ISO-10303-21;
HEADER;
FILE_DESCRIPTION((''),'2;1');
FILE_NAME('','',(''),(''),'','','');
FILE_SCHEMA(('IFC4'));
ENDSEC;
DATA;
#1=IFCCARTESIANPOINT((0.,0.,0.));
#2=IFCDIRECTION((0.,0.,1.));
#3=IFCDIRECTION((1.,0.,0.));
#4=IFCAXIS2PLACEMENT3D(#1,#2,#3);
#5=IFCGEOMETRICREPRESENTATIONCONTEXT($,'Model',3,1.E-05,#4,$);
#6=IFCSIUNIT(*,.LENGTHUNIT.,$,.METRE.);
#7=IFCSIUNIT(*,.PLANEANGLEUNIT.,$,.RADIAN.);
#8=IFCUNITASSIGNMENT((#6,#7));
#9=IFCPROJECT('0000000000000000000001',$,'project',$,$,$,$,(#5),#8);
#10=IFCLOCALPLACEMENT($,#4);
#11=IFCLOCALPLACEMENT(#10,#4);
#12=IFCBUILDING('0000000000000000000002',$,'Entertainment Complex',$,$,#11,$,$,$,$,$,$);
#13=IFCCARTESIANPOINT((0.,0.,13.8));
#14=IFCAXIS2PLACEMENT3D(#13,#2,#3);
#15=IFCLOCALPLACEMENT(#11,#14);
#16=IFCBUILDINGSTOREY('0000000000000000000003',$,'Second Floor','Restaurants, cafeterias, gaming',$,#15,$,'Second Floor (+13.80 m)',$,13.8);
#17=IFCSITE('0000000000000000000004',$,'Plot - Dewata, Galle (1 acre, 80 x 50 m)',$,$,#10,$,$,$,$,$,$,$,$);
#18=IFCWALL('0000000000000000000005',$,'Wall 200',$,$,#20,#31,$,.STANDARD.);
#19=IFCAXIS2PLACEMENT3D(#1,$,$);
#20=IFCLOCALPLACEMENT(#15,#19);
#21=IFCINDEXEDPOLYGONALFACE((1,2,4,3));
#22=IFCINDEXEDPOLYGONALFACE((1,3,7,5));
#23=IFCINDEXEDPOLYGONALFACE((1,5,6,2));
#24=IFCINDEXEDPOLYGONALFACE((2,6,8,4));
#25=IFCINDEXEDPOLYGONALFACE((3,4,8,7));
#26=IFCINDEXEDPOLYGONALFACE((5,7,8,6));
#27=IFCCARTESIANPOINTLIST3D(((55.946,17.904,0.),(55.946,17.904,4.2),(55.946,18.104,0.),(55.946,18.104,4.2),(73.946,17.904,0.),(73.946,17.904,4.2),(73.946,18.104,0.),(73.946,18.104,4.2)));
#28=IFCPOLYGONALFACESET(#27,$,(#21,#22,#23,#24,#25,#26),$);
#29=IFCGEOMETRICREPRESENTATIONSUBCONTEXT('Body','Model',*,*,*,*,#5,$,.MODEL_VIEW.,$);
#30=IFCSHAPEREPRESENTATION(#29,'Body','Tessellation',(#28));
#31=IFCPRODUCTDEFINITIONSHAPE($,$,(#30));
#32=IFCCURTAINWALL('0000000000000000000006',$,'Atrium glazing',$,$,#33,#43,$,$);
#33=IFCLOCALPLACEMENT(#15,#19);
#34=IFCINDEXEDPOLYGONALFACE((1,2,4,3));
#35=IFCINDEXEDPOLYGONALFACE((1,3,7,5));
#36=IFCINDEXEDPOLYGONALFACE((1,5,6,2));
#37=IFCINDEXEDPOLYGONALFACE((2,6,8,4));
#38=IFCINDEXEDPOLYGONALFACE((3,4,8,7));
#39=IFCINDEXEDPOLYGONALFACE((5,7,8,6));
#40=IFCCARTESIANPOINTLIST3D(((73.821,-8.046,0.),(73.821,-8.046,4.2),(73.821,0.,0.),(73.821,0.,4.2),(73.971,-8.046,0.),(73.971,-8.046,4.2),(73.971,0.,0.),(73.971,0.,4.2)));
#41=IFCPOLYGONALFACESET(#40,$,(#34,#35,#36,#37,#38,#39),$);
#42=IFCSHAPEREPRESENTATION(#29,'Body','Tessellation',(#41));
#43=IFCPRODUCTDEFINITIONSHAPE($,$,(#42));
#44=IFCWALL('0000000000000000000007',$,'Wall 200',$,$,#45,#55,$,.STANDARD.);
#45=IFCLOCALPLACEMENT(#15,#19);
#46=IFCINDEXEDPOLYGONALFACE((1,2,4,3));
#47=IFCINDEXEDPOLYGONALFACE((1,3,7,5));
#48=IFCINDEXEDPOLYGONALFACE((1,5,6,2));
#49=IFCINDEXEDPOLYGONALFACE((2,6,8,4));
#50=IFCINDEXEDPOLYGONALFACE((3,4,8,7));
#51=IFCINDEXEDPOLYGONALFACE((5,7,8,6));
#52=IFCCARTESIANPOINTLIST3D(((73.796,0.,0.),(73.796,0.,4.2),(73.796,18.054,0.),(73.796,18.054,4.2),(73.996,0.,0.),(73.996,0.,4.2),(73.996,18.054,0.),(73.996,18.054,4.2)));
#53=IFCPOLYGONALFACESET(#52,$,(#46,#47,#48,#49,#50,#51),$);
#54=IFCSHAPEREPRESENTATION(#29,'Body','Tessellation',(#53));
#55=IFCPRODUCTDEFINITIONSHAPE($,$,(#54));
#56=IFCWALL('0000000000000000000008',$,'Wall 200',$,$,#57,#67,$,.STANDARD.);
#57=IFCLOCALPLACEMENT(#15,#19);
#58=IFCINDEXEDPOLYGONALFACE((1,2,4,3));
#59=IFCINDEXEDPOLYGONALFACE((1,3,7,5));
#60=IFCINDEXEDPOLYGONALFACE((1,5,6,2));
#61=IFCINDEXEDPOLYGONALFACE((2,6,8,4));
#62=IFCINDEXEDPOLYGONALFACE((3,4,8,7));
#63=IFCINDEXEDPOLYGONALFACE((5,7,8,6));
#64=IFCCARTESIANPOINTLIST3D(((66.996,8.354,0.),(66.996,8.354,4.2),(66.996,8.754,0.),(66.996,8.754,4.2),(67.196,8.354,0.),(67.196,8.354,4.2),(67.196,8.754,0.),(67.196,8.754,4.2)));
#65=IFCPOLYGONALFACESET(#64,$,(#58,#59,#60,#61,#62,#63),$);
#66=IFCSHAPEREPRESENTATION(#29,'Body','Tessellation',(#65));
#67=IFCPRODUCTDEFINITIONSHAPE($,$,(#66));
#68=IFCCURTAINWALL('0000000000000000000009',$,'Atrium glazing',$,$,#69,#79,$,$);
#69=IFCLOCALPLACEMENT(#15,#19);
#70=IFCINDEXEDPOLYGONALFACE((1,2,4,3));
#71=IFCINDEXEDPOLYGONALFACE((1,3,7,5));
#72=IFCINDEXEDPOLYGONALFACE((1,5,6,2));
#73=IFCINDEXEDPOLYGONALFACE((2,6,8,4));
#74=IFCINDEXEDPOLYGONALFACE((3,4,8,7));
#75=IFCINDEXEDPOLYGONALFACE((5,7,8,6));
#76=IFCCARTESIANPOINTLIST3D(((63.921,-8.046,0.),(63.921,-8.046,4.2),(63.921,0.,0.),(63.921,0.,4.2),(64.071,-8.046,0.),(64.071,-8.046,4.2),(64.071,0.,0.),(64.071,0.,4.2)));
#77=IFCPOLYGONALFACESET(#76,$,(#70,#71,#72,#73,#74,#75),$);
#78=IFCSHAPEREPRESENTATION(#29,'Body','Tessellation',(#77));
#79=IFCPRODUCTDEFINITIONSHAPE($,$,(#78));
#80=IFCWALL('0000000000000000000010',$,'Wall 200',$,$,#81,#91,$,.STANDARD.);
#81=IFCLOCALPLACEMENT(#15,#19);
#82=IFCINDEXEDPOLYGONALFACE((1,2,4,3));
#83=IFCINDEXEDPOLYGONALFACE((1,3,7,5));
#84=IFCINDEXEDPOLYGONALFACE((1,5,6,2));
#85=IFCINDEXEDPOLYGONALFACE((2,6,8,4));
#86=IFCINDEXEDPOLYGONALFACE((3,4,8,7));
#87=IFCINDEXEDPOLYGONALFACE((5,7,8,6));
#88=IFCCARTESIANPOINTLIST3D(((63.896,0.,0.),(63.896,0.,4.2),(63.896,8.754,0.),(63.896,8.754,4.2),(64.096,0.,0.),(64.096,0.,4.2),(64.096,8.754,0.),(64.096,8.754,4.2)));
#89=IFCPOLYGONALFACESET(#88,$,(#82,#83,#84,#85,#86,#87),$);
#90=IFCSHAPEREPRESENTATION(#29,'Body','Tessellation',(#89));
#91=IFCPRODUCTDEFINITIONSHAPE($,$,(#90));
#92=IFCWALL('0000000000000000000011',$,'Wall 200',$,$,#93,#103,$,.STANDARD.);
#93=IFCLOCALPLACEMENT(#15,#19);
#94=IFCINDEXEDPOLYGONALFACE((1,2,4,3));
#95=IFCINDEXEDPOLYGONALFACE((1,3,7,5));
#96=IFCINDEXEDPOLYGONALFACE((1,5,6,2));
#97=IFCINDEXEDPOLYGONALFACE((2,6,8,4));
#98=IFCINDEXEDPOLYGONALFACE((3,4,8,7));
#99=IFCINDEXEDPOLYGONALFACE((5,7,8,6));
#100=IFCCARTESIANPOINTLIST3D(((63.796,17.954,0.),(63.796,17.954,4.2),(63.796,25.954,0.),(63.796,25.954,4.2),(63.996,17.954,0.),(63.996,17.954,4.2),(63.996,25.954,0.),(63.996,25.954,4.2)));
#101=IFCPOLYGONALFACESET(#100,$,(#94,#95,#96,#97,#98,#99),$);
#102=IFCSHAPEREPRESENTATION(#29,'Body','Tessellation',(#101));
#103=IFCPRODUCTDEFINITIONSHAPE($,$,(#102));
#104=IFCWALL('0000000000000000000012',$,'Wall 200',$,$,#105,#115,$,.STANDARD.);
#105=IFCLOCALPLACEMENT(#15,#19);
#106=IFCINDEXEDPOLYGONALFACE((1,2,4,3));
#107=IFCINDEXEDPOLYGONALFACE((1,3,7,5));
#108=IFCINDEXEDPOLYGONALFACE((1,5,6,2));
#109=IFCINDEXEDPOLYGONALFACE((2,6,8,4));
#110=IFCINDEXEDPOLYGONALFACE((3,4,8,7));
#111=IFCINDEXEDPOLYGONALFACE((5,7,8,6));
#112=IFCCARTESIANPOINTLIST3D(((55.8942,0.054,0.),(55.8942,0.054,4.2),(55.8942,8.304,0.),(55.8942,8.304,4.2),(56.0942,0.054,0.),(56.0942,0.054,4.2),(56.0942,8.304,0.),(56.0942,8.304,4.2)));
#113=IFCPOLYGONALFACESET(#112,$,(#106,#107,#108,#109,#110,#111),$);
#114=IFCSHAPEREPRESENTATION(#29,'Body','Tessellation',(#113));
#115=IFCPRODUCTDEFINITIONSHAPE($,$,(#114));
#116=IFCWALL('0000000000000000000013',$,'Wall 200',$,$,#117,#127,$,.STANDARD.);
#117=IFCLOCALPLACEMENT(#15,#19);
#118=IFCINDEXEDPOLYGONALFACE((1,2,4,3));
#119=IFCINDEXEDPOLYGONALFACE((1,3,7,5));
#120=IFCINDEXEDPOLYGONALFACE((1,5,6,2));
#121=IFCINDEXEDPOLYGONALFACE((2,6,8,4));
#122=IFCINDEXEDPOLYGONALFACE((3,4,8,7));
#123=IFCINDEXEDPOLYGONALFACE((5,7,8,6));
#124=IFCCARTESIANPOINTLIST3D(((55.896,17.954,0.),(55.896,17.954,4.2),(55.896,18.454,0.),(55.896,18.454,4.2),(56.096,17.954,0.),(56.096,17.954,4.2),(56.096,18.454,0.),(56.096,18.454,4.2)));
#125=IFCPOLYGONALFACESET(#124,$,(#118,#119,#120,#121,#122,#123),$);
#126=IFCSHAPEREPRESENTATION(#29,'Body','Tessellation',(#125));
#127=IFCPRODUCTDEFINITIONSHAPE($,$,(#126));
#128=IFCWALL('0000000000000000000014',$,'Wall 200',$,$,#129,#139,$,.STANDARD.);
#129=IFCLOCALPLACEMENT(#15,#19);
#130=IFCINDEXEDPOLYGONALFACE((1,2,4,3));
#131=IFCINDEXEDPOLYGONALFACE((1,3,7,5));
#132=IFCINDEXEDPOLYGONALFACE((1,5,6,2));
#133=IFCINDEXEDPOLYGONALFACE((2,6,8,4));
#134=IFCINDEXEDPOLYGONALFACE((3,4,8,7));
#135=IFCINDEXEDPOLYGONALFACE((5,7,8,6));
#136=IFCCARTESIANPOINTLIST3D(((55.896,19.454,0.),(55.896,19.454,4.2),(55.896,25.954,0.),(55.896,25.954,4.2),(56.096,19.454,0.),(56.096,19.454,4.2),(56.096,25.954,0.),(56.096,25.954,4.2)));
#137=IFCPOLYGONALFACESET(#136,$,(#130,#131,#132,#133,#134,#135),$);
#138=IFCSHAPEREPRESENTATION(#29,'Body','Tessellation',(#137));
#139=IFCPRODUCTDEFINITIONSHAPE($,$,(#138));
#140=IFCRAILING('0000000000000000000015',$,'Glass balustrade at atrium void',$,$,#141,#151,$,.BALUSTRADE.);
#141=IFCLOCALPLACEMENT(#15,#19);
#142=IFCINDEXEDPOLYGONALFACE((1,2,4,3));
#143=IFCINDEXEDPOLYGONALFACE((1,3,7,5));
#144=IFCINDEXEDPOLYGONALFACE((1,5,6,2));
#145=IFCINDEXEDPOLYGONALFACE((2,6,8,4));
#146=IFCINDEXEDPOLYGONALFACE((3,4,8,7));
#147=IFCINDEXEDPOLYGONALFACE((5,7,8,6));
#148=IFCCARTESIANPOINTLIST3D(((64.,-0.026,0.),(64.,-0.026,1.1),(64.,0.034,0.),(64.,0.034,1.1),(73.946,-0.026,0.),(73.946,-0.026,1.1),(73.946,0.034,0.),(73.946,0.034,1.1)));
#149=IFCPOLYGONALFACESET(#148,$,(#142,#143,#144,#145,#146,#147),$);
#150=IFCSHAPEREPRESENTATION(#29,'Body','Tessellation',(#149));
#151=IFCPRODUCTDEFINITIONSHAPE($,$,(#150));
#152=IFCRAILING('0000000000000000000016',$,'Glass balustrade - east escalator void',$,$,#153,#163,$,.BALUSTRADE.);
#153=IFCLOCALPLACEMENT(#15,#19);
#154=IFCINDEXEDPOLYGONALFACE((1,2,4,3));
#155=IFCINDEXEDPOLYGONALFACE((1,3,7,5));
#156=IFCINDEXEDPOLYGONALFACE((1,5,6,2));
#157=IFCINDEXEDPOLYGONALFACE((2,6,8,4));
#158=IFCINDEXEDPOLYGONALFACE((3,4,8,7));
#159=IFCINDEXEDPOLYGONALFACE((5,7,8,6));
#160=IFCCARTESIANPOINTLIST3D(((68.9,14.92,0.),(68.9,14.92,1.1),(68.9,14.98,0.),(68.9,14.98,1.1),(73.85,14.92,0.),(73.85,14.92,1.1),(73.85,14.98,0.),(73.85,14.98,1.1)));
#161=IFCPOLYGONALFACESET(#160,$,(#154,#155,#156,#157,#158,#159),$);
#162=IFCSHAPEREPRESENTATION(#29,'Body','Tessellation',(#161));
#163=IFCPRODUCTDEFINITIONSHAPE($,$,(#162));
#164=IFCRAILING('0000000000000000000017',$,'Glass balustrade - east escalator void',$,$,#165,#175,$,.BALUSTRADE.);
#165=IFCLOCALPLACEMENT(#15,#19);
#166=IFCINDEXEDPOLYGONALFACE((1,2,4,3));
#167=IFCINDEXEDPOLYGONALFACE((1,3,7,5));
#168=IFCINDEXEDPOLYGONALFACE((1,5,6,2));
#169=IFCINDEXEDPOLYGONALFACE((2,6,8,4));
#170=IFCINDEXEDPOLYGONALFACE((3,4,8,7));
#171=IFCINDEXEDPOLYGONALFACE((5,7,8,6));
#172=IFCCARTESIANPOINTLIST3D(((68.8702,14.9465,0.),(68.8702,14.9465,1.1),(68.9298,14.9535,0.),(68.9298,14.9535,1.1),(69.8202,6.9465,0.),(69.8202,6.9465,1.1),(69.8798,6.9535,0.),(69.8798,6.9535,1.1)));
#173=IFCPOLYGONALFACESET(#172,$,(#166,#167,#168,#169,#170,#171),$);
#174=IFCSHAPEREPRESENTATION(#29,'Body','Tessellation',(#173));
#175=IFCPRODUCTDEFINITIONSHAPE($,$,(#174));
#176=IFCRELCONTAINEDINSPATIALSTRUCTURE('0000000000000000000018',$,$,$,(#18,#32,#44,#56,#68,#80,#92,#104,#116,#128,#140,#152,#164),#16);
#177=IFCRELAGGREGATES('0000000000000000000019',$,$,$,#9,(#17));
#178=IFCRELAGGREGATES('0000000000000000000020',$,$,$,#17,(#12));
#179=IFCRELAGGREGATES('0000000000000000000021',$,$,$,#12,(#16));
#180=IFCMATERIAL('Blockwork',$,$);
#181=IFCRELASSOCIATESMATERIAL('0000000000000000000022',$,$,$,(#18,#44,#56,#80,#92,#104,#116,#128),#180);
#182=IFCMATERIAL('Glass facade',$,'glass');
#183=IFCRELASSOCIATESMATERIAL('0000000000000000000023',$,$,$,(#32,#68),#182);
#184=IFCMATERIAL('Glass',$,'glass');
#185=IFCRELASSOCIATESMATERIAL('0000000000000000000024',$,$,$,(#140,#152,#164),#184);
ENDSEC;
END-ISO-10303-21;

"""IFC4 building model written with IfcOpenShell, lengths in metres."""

from ifc_helpers import new_model, si_unit, frame, origin_with_axes, place, context, subcontext, project, spatial, polyline, outline, extrude, material, element, save


model = new_model("IFC4")

# Units and contexts
model_context = context("Model", 3, precision=1e-05, world=origin_with_axes())
body_context = subcontext(model_context, "Body", "Model", "MODEL_VIEW")
ifc_project = project(units=[si_unit("LENGTHUNIT", "METRE"), si_unit("PLANEANGLEUNIT", "RADIAN")], contexts=[model_context])

# Site, building, storey
site_placement = place(None, origin_with_axes())
site = spatial("IfcSite", under=ifc_project, at=site_placement, Name="Plot - Dewata, Galle (1 acre, 80 x 50 m)")
building_placement = place(site_placement, origin_with_axes())
building = spatial("IfcBuilding", under=site, at=building_placement, Name="Entertainment Complex")
storey_placement = place(building_placement, frame((0.0, 0.0, 13.8), z_axis=(0.0, 0.0, 1.0), x_axis=(1.0, 0.0, 0.0)))
storey = spatial("IfcBuildingStorey", under=building, at=storey_placement, Name="Second Floor", Description="Restaurants, cafeterias, gaming", LongName="Second Floor (+13.80 m)", Elevation=13.8)

# Shared definitions
ifc_material_1 = material(Name="Glass facade", Category="glass")

# Wall
ifc_material_2 = material(Name="Blockwork")
wall_1_placement = place(storey_placement, frame((55.946, 18.004, 0.0), z_axis=(0.0, 0.0, 1.0), x_axis=(1.0, 0.0, 0.0)))
element("IfcWall", 1, at=wall_1_placement, inside=storey, material=ifc_material_2, Name="Wall 200", PredefinedType="STANDARD", context=body_context, shape_type="SweptSolid", body=[
    extrude(outline(polyline([(0.0, -0.1), (18.0, -0.1), (18.0, 0.1), (0.0, 0.1), (0.0, -0.1)])), origin_with_axes(), (0.0, 0.0, 1.0), 4.2),
])

# Curtain wall
curtain_wall_1_placement = place(storey_placement, frame((73.896, -8.046, 0.0), z_axis=(0.0, 0.0, 1.0), x_axis=(0.0, 1.0, 0.0)))
element("IfcCurtainWall", 2, at=curtain_wall_1_placement, inside=storey, material=ifc_material_1, Name="Atrium glazing", context=body_context, shape_type="SweptSolid", body=[
    extrude(outline(polyline([(0.0, -0.075), (8.046, -0.075), (8.046, 0.075), (0.0, 0.075), (0.0, -0.075)])), origin_with_axes(), (0.0, 0.0, 1.0), 4.2),
])

# Walls
wall_2_placement = place(storey_placement, frame((73.896, 0.0, 0.0), z_axis=(0.0, 0.0, 1.0), x_axis=(0.0, 1.0, 0.0)))
element("IfcWall", 3, at=wall_2_placement, inside=storey, material=ifc_material_2, Name="Wall 200", PredefinedType="STANDARD", context=body_context, shape_type="SweptSolid", body=[
    extrude(outline(polyline([(0.0, -0.1), (18.054, -0.1), (18.054, 0.1), (0.0, 0.1), (0.0, -0.1)])), origin_with_axes(), (0.0, 0.0, 1.0), 4.2),
])
wall_3_placement = place(storey_placement, frame((67.096, 8.354, 0.0), z_axis=(0.0, 0.0, 1.0), x_axis=(0.0, 1.0, 0.0)))
element("IfcWall", 4, at=wall_3_placement, inside=storey, material=ifc_material_2, Name="Wall 200", PredefinedType="STANDARD", context=body_context, shape_type="SweptSolid", body=[
    extrude(outline(polyline([(0.0, -0.1), (0.4, -0.1), (0.4, 0.1), (0.0, 0.1), (0.0, -0.1)])), origin_with_axes(), (0.0, 0.0, 1.0), 4.2),
])

# Curtain wall
curtain_wall_2_placement = place(storey_placement, frame((63.996, -8.046, 0.0), z_axis=(0.0, 0.0, 1.0), x_axis=(0.0, 1.0, 0.0)))
element("IfcCurtainWall", 5, at=curtain_wall_2_placement, inside=storey, material=ifc_material_1, Name="Atrium glazing", context=body_context, shape_type="SweptSolid", body=[
    extrude(outline(polyline([(0.0, -0.075), (8.046, -0.075), (8.046, 0.075), (0.0, 0.075), (0.0, -0.075)])), origin_with_axes(), (0.0, 0.0, 1.0), 4.2),
])

# Walls
wall_4_placement = place(storey_placement, frame((63.996, 0.0, 0.0), z_axis=(0.0, 0.0, 1.0), x_axis=(0.0, 1.0, 0.0)))
element("IfcWall", 6, at=wall_4_placement, inside=storey, material=ifc_material_2, Name="Wall 200", PredefinedType="STANDARD", context=body_context, shape_type="SweptSolid", body=[
    extrude(outline(polyline([(0.0, -0.1), (8.754, -0.1), (8.754, 0.1), (0.0, 0.1), (0.0, -0.1)])), origin_with_axes(), (0.0, 0.0, 1.0), 4.2),
])
wall_5_placement = place(storey_placement, frame((63.896, 17.954, 0.0), z_axis=(0.0, 0.0, 1.0), x_axis=(0.0, 1.0, 0.0)))
element("IfcWall", 7, at=wall_5_placement, inside=storey, material=ifc_material_2, Name="Wall 200", PredefinedType="STANDARD", context=body_context, shape_type="SweptSolid", body=[
    extrude(outline(polyline([(0.0, -0.1), (8.0, -0.1), (8.0, 0.1), (0.0, 0.1), (0.0, -0.1)])), origin_with_axes(), (0.0, 0.0, 1.0), 4.2),
])
wall_6_placement = place(storey_placement, frame((55.9942, 0.054, 0.0), z_axis=(0.0, 0.0, 1.0), x_axis=(0.0, 1.0, 0.0)))
element("IfcWall", 8, at=wall_6_placement, inside=storey, material=ifc_material_2, Name="Wall 200", PredefinedType="STANDARD", context=body_context, shape_type="SweptSolid", body=[
    extrude(outline(polyline([(0.0, -0.1), (8.25, -0.1), (8.25, 0.1), (0.0, 0.1), (0.0, -0.1)])), origin_with_axes(), (0.0, 0.0, 1.0), 4.2),
])
wall_7_placement = place(storey_placement, frame((55.996, 17.954, 0.0), z_axis=(0.0, 0.0, 1.0), x_axis=(0.0, 1.0, 0.0)))
element("IfcWall", 9, at=wall_7_placement, inside=storey, material=ifc_material_2, Name="Wall 200", PredefinedType="STANDARD", context=body_context, shape_type="SweptSolid", body=[
    extrude(outline(polyline([(0.0, -0.1), (0.5, -0.1), (0.5, 0.1), (0.0, 0.1), (0.0, -0.1)])), origin_with_axes(), (0.0, 0.0, 1.0), 4.2),
])
wall_8_placement = place(storey_placement, frame((55.996, 19.454, 0.0), z_axis=(0.0, 0.0, 1.0), x_axis=(0.0, 1.0, 0.0)))
element("IfcWall", 10, at=wall_8_placement, inside=storey, material=ifc_material_2, Name="Wall 200", PredefinedType="STANDARD", context=body_context, shape_type="SweptSolid", body=[
    extrude(outline(polyline([(0.0, -0.1), (6.5, -0.1), (6.5, 0.1), (0.0, 0.1), (0.0, -0.1)])), origin_with_axes(), (0.0, 0.0, 1.0), 4.2),
])

# Railings
ifc_material_3 = material(Name="Glass", Category="glass")
railing_1_placement = place(storey_placement, frame((64.0, 0.004, 0.0), z_axis=(0.0, 0.0, 1.0), x_axis=(1.0, 0.0, 0.0)))
element("IfcRailing", 11, at=railing_1_placement, inside=storey, material=ifc_material_3, Name="Glass balustrade at atrium void", PredefinedType="BALUSTRADE", context=body_context, shape_type="SweptSolid", body=[
    extrude(outline(polyline([(0.0, -0.03), (9.946, -0.03), (9.946, 0.03), (0.0, 0.03), (0.0, -0.03)])), origin_with_axes(), (0.0, 0.0, 1.0), 1.1),
])
railing_2_placement = place(storey_placement, frame((68.9, 14.95, 0.0), z_axis=(0.0, 0.0, 1.0), x_axis=(1.0, 0.0, 0.0)))
element("IfcRailing", 12, at=railing_2_placement, inside=storey, material=ifc_material_3, Name="Glass balustrade - east escalator void", PredefinedType="BALUSTRADE", context=body_context, shape_type="SweptSolid", body=[
    extrude(outline(polyline([(0.0, -0.03), (4.95, -0.03), (4.95, 0.03), (0.0, 0.03), (0.0, -0.03)])), origin_with_axes(), (0.0, 0.0, 1.0), 1.1),
])
railing_3_placement = place(storey_placement, frame((69.85, 6.95, 0.0), z_axis=(0.0, 0.0, 1.0), x_axis=(-0.117921, 0.993023, 0.0)))
element("IfcRailing", 13, at=railing_3_placement, inside=storey, material=ifc_material_3, Name="Glass balustrade - east escalator void", PredefinedType="BALUSTRADE", context=body_context, shape_type="SweptSolid", body=[
    extrude(outline(polyline([(0.0, -0.03), (8.0562, -0.03), (8.0562, 0.03), (0.0, 0.03), (0.0, -0.03)])), origin_with_axes(), (0.0, 0.0, 1.0), 1.1),
])

save(model, "model.ifc")
